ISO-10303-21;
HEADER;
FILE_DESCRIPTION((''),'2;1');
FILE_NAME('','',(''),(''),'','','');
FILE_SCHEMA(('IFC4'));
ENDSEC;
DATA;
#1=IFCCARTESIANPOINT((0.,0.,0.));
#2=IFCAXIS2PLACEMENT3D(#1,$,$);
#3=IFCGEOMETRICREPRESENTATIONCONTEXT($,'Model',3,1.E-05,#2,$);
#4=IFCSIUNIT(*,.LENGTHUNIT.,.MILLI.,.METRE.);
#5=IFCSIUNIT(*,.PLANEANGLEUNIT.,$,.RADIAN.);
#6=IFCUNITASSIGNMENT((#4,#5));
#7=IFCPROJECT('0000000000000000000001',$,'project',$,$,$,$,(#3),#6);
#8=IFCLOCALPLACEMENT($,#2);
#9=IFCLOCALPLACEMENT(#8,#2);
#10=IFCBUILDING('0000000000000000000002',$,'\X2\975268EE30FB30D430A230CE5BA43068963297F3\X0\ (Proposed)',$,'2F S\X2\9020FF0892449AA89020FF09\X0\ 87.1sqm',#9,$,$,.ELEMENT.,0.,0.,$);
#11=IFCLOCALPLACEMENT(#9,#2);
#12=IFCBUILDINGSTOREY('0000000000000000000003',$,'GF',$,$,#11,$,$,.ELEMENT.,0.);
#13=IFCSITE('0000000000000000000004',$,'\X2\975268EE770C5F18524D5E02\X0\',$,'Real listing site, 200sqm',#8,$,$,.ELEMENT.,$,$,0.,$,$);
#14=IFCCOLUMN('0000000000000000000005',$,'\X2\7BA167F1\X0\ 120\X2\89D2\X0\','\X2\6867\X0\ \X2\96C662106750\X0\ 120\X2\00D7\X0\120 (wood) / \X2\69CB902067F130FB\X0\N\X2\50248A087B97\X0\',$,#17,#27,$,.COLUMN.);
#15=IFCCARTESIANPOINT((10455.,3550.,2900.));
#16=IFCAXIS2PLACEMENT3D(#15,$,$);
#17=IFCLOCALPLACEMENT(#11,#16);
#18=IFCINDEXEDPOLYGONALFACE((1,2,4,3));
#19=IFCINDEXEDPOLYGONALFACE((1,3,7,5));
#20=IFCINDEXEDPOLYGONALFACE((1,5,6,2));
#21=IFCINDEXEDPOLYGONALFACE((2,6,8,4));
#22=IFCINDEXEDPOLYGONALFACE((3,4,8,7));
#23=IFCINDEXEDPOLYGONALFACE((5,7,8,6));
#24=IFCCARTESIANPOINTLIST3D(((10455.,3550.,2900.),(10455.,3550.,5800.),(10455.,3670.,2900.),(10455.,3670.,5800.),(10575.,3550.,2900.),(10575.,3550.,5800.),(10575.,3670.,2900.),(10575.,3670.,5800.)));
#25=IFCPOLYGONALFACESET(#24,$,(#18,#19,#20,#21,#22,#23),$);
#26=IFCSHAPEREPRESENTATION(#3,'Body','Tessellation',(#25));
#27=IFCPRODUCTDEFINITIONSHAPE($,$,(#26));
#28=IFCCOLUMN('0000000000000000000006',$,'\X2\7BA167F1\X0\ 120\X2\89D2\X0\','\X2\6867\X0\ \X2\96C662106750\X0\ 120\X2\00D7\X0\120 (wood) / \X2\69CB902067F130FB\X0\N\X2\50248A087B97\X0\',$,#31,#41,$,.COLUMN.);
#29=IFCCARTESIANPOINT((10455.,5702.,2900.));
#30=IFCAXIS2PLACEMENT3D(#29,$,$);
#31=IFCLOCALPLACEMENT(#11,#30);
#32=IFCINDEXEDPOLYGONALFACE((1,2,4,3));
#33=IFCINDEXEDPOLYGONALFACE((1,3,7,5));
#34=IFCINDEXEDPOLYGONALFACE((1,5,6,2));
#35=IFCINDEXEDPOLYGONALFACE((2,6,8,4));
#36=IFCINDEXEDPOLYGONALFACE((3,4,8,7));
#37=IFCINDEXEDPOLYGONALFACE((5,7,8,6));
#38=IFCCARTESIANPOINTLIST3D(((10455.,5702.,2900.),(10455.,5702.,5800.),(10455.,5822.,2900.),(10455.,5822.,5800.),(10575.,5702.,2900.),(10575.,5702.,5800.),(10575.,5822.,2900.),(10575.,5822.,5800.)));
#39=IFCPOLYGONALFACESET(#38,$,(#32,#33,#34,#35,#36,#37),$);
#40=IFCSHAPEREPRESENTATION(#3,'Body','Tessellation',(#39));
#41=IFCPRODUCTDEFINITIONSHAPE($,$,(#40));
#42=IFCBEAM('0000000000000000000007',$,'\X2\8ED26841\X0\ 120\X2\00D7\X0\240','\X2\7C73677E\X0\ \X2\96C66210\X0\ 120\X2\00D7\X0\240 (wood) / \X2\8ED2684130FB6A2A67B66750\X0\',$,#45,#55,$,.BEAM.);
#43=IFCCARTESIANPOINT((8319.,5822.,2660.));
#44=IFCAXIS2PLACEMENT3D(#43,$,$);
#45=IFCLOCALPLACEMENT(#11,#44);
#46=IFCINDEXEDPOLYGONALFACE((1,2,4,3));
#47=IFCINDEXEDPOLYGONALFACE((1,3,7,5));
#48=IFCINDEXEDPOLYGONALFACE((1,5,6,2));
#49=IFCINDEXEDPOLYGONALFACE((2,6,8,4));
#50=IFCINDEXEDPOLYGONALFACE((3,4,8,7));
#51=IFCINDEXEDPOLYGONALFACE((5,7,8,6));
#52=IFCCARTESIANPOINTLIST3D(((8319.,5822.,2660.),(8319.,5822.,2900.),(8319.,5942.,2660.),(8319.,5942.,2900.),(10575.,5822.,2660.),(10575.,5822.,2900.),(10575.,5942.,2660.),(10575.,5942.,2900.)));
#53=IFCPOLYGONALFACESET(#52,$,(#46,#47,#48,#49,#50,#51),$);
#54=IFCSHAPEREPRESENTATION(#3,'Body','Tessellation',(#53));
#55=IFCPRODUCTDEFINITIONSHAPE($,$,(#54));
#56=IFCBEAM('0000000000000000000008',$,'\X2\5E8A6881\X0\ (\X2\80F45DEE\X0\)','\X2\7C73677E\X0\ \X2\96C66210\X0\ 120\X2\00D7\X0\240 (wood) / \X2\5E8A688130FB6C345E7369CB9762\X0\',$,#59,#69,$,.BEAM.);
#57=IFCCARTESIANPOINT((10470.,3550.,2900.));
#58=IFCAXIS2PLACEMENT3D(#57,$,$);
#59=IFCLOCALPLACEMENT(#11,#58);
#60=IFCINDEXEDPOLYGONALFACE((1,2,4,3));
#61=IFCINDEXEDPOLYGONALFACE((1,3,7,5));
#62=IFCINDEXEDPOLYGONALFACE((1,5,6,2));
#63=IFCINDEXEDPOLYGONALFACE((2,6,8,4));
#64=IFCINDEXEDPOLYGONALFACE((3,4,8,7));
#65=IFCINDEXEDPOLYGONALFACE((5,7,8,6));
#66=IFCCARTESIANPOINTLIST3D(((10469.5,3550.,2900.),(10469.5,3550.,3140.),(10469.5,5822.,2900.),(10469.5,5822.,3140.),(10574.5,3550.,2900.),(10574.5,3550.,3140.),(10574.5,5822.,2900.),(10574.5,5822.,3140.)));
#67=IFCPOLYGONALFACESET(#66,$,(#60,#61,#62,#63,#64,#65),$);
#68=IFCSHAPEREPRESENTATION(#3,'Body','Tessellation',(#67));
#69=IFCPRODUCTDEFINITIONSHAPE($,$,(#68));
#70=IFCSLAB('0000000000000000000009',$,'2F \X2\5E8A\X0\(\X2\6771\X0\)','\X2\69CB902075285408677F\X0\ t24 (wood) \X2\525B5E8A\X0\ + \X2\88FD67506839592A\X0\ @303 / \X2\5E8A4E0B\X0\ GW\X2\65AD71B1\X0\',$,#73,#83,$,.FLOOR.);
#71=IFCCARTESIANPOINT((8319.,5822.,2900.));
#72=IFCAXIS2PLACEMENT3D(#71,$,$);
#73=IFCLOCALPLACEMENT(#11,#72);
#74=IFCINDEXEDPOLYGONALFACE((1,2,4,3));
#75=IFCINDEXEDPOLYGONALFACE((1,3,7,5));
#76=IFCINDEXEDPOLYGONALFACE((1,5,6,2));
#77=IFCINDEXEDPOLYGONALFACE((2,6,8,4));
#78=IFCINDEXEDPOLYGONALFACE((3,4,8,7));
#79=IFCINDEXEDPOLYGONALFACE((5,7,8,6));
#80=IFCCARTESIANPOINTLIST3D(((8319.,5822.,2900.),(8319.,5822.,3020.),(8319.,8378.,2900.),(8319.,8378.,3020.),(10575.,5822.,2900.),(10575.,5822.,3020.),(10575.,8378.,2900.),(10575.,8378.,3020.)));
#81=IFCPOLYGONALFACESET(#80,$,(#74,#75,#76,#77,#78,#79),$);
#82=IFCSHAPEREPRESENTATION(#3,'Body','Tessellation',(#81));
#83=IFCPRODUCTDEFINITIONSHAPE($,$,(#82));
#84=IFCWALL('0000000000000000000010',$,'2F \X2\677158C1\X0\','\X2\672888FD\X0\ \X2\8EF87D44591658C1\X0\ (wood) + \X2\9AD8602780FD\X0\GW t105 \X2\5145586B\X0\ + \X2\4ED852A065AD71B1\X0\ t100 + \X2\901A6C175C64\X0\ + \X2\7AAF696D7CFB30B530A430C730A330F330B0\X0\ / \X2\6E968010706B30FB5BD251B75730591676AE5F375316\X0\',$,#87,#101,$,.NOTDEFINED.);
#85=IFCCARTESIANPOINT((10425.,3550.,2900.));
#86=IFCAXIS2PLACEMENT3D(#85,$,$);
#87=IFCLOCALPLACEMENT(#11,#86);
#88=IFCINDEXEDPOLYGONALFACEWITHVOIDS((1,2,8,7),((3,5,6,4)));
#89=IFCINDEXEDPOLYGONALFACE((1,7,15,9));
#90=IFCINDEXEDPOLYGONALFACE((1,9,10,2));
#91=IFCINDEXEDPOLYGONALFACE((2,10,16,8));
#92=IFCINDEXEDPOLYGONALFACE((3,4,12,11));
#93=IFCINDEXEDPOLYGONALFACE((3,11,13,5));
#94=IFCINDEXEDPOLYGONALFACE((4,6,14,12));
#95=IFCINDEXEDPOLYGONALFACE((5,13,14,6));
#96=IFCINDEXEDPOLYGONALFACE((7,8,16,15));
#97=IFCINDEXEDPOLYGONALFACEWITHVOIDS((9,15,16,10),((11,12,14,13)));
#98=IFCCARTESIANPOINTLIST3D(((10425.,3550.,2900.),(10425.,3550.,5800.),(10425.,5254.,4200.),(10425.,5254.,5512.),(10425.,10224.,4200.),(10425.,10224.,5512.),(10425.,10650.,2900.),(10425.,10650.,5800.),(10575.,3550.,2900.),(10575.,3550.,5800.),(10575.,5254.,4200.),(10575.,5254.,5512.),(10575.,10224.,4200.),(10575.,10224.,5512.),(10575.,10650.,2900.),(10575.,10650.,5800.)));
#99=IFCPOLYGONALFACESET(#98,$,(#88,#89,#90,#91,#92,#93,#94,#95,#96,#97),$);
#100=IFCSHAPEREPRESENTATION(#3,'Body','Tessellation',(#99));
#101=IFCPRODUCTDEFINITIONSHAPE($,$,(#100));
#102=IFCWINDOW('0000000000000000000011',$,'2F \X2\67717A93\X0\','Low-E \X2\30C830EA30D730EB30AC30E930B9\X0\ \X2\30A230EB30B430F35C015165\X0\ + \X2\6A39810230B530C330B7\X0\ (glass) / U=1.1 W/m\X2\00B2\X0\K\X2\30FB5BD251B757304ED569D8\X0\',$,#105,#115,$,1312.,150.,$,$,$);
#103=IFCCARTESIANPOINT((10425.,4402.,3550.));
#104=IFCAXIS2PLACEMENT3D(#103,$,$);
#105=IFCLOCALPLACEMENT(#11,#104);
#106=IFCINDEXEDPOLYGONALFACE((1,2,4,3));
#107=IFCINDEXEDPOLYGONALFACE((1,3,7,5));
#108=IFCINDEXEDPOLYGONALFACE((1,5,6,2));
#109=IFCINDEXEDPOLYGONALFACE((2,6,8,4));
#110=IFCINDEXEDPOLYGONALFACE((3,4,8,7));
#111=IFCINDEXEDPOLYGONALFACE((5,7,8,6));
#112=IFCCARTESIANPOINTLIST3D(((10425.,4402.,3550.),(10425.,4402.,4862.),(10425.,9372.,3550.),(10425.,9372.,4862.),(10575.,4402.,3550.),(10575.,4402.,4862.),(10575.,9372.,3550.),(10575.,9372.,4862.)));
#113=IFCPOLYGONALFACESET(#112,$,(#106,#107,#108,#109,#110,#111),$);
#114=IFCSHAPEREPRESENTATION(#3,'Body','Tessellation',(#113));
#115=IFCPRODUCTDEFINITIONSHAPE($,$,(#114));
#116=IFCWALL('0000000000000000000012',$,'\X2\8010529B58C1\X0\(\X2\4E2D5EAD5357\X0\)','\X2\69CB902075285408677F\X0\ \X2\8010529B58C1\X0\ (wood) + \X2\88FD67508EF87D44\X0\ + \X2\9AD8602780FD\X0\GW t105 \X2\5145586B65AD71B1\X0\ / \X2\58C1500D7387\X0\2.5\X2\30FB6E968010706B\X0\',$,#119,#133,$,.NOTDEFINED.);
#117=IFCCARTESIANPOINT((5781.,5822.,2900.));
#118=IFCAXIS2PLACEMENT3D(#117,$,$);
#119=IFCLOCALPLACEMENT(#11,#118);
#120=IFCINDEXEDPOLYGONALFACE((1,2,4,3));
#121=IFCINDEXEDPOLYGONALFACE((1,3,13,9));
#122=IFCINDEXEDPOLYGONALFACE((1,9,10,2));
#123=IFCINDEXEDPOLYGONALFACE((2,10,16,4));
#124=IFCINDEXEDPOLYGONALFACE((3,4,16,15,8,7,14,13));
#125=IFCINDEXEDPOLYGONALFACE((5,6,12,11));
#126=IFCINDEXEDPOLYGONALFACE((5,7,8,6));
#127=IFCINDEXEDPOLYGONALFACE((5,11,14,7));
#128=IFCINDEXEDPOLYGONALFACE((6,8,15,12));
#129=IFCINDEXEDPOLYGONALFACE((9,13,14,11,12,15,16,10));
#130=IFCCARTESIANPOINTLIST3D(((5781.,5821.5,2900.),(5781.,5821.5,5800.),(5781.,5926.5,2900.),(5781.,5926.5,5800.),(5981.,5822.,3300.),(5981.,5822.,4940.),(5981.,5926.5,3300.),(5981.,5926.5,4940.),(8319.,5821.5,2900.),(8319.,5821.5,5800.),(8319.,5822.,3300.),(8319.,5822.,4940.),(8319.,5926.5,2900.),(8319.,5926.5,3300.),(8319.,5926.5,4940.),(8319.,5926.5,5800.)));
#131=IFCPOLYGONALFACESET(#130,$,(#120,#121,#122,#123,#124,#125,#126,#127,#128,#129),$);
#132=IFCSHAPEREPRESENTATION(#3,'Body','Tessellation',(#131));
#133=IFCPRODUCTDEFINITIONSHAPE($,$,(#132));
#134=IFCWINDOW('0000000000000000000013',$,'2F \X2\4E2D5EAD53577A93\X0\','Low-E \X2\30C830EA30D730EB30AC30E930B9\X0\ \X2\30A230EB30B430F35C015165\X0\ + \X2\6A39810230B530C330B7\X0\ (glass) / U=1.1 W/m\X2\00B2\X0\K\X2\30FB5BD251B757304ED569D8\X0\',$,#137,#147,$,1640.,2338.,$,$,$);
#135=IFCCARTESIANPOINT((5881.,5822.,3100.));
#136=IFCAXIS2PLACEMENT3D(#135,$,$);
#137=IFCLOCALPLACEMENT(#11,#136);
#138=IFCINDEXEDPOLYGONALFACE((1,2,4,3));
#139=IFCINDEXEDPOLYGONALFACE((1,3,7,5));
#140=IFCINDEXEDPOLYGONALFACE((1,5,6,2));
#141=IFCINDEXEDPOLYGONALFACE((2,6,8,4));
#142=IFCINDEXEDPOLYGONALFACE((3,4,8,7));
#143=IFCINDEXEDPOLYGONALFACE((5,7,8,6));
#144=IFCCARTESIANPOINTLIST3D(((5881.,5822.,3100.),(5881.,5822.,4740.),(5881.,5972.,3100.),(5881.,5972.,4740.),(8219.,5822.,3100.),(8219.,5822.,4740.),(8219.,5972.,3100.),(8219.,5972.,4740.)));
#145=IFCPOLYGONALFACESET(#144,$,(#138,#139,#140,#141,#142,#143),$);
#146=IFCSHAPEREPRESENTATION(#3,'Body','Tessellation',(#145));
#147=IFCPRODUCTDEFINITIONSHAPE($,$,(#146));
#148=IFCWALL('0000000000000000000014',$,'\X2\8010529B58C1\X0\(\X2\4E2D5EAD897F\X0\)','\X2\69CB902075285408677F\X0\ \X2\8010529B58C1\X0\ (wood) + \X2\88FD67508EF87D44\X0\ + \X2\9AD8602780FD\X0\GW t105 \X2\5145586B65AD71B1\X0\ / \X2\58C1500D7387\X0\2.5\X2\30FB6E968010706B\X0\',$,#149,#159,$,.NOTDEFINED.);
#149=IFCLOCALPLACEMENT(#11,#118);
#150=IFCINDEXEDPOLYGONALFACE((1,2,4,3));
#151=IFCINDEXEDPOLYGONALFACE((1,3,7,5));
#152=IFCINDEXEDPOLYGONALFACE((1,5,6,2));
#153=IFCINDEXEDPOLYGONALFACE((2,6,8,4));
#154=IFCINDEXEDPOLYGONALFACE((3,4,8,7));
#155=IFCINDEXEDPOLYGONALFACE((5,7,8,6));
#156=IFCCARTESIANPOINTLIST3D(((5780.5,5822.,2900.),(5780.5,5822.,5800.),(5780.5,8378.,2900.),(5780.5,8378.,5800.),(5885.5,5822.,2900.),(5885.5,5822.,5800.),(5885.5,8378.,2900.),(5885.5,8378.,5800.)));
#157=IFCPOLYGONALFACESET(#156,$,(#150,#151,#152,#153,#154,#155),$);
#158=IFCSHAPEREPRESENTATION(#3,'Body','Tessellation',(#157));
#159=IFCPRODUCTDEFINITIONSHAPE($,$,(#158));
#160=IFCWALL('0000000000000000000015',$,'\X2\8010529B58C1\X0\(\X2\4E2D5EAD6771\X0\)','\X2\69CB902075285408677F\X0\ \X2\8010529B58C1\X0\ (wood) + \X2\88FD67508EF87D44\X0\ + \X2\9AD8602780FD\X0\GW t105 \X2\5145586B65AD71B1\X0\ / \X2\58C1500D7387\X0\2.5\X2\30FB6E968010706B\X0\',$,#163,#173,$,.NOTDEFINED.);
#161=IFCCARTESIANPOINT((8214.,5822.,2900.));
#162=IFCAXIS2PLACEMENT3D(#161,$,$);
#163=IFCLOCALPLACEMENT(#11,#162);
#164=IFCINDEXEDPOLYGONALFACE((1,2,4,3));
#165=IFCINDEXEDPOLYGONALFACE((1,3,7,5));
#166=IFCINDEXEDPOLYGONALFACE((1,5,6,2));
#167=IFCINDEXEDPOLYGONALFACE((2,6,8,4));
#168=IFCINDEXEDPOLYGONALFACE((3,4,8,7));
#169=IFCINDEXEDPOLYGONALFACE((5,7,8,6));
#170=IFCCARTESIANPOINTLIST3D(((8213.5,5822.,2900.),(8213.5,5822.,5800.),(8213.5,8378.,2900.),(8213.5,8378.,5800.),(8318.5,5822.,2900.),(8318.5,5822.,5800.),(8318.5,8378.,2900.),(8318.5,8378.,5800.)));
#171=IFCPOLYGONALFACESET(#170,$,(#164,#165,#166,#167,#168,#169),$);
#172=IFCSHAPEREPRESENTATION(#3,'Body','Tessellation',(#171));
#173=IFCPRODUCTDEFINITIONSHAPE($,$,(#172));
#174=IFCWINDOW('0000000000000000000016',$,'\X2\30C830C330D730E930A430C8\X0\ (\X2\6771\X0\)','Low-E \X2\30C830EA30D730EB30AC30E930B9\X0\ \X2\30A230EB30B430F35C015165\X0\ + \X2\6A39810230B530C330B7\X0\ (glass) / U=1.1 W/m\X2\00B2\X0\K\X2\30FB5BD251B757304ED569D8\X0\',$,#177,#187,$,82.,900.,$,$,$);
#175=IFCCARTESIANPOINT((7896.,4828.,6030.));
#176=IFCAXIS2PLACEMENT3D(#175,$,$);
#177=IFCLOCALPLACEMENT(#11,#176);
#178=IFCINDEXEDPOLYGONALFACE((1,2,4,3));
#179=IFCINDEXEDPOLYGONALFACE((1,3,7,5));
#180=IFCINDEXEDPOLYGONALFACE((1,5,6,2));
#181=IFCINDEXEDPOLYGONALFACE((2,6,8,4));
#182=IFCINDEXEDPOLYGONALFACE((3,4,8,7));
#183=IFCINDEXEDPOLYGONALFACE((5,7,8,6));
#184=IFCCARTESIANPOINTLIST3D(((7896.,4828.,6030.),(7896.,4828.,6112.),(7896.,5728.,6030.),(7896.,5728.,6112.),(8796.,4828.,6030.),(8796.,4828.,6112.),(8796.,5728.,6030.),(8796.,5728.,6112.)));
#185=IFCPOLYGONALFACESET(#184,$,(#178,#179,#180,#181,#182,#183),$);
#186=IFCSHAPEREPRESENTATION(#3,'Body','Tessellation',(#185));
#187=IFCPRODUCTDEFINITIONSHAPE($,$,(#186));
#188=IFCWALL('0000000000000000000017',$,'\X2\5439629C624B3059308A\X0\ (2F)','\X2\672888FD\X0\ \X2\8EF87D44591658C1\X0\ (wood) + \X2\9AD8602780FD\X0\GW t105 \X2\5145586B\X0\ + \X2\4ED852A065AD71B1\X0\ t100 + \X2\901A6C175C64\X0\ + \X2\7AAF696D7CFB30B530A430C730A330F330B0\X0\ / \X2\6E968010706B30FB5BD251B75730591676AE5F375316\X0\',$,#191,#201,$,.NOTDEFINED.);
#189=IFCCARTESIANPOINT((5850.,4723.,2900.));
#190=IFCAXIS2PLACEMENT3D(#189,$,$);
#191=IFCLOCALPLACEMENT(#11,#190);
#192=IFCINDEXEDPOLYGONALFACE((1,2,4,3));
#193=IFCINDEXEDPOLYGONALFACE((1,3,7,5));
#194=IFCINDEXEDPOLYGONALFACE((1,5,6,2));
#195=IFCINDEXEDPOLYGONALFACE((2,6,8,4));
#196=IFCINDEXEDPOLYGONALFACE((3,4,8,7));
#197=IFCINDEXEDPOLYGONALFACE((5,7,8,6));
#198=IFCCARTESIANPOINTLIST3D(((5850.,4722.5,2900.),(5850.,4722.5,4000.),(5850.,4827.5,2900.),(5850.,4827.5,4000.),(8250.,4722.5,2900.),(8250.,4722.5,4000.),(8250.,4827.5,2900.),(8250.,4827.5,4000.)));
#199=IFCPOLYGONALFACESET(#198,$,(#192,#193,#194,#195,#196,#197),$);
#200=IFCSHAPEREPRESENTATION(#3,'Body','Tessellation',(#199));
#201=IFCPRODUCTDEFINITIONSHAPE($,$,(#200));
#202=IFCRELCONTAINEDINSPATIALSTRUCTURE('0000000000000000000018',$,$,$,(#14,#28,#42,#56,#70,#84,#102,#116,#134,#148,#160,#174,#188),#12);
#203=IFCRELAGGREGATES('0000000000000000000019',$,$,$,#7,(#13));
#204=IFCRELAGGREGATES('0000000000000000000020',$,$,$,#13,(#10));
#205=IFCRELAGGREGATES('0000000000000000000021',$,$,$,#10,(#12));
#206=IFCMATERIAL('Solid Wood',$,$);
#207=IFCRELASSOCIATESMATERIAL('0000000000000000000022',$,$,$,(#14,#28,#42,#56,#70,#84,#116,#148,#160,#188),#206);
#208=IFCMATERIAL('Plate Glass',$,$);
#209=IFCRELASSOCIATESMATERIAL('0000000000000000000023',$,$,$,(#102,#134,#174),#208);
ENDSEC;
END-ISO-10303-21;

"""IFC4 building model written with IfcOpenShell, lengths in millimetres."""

from ifc_helpers import new_model, si_unit, frame, frame_2d, origin, place, context, project, spatial, rectangle, extrude, material, element, fill, save


model = new_model("IFC4")

# Units and contexts
model_context = context("Model", 3, precision=1e-05, world=origin())
ifc_project = project(units=[si_unit("LENGTHUNIT", "METRE", prefix="MILLI"), si_unit("PLANEANGLEUNIT", "RADIAN")], contexts=[model_context])

# Site, building, storey
site_placement = place(None, origin())
site = spatial("IfcSite", under=ifc_project, at=site_placement, Name="青森県弘前市", ObjectType="Real listing site, 200sqm", CompositionType="ELEMENT", RefElevation=0.0)
building_placement = place(site_placement, origin())
building = spatial("IfcBuilding", under=site, at=building_placement, Name="青森・ピアノ室と防音 (Proposed)", ObjectType="2F S造（鉄骨造） 87.1sqm", CompositionType="ELEMENT", ElevationOfRefHeight=0.0, ElevationOfTerrain=0.0)
storey_placement = place(building_placement, origin())
storey = spatial("IfcBuildingStorey", under=building, at=storey_placement, Name="GF", CompositionType="ELEMENT", Elevation=0.0)

# Columns
ifc_material_1 = material(Name="Solid Wood")
column_1_placement = place(storey_placement, frame((10455.0, 3550.0, 2900.0)))
element("IfcColumn", 1, at=column_1_placement, inside=storey, material=ifc_material_1, Name="管柱 120角", Description="桧 集成材 120×120 (wood) / 構造柱・N値計算", PredefinedType="COLUMN", context=model_context, shape_type="SweptSolid", body=[
    extrude(rectangle(XDim=120.0, YDim=120.0, at=frame_2d((60.0, 60.0))), frame((10455.0, 3550.0, 2900.0)), (0.0, 0.0, 1.0), 2900.0),
])
column_2_placement = place(storey_placement, frame((10455.0, 5702.0, 2900.0)))
element("IfcColumn", 2, at=column_2_placement, inside=storey, material=ifc_material_1, Name="管柱 120角", Description="桧 集成材 120×120 (wood) / 構造柱・N値計算", PredefinedType="COLUMN", context=model_context, shape_type="SweptSolid", body=[
    extrude(rectangle(XDim=120.0, YDim=120.0, at=frame_2d((60.0, 60.0))), frame((10455.0, 5702.0, 2900.0)), (0.0, 0.0, 1.0), 2900.0),
])

# Beams
beam_1_placement = place(storey_placement, frame((8319.0, 5822.0, 2660.0)))
element("IfcBeam", 3, at=beam_1_placement, inside=storey, material=ifc_material_1, Name="軒桁 120×240", Description="米松 集成 120×240 (wood) / 軒桁・横架材", PredefinedType="BEAM", context=model_context, shape_type="SweptSolid", body=[
    extrude(rectangle(XDim=2256.0, YDim=120.0, at=frame_2d((1128.0, 60.0))), frame((8319.0, 5822.0, 2660.0)), (0.0, 0.0, 1.0), 240.0),
])
beam_2_placement = place(storey_placement, frame((10470.0, 3550.0, 2900.0)))
element("IfcBeam", 4, at=beam_2_placement, inside=storey, material=ifc_material_1, Name="床梁 (胴差)", Description="米松 集成 120×240 (wood) / 床梁・水平構面", PredefinedType="BEAM", context=model_context, shape_type="SweptSolid", body=[
    extrude(rectangle(XDim=105.0, YDim=2272.0, at=frame_2d((52.0, 1136.0))), frame((10470.0, 3550.0, 2900.0)), (0.0, 0.0, 1.0), 240.0),
])

# Slab
slab_placement = place(storey_placement, frame((8319.0, 5822.0, 2900.0)))
element("IfcSlab", 5, at=slab_placement, inside=storey, material=ifc_material_1, Name="2F 床(東)", Description="構造用合板 t24 (wood) 剛床 + 製材根太 @303 / 床下 GW断熱", PredefinedType="FLOOR", context=model_context, shape_type="SweptSolid", body=[
    extrude(rectangle(XDim=2256.0, YDim=2556.0, at=frame_2d((1128.0, 1278.0))), frame((8319.0, 5822.0, 2900.0)), (0.0, 0.0, 1.0), 120.0),
])

# Walls, openings, windows
wall_1_placement = place(storey_placement, frame((10425.0, 3550.0, 2900.0)))
wall_1 = element("IfcWall", 6, at=wall_1_placement, inside=storey, material=ifc_material_1, Name="2F 東壁", Description="木製 軸組外壁 (wood) + 高性能GW t105 充填 + 付加断熱 t100 + 通気層 + 窯業系サイディング / 準耐火・寒冷地外皮強化", PredefinedType="NOTDEFINED", context=model_context, shape_type="SweptSolid", body=[
    extrude(rectangle(XDim=150.0, YDim=7100.0, at=frame_2d((75.0, 3550.0))), frame((10425.0, 3550.0, 2900.0)), (0.0, 0.0, 1.0), 2900.0),
])
opening_1_placement = place(storey_placement, frame((10425.0, 4402.0, 3550.0)))
opening_1 = element("IfcOpeningElement", 7, at=opening_1_placement, cuts=wall_1, PredefinedType="NOTDEFINED", context=model_context, shape_type="SweptSolid", body=[
    extrude(rectangle(XDim=150.0, YDim=4970.0, at=frame_2d((75.0, 2485.0))), frame((10425.0, 4402.0, 3550.0)), (0.0, 0.0, 1.0), 1312.0),
])
ifc_material_2 = material(Name="Plate Glass")
window_1_placement = place(storey_placement, frame((10425.0, 4402.0, 3550.0)))
window_1 = element("IfcWindow", 8, at=window_1_placement, inside=storey, material=ifc_material_2, Name="2F 東窓", Description="Low-E トリプルガラス アルゴン封入 + 樹脂サッシ (glass) / U=1.1 W/m²K・寒冷地仕様", OverallHeight=1312.0, OverallWidth=150.0, context=model_context, shape_type="SweptSolid", body=[
    extrude(rectangle(XDim=150.0, YDim=4970.0, at=frame_2d((75.0, 2485.0))), frame((10425.0, 4402.0, 3550.0)), (0.0, 0.0, 1.0), 1312.0),
])
fill(opening_1, window_1)
wall_2_placement = place(storey_placement, frame((5781.0, 5822.0, 2900.0)))
wall_2 = element("IfcWall", 9, at=wall_2_placement, inside=storey, material=ifc_material_1, Name="耐力壁(中庭南)", Description="構造用合板 耐力壁 (wood) + 製材軸組 + 高性能GW t105 充填断熱 / 壁倍率2.5・準耐火", PredefinedType="NOTDEFINED", context=model_context, shape_type="SweptSolid", body=[
    extrude(rectangle(XDim=2538.0, YDim=105.0, at=frame_2d((1269.0, 52.0))), frame((5781.0, 5822.0, 2900.0)), (0.0, 0.0, 1.0), 2900.0),
])
opening_2_placement = place(storey_placement, frame((5881.0, 5822.0, 3100.0)))
opening_2 = element("IfcOpeningElement", 10, at=opening_2_placement, cuts=wall_2, PredefinedType="NOTDEFINED", context=model_context, shape_type="SweptSolid", body=[
    extrude(rectangle(XDim=2338.0, YDim=150.0, at=frame_2d((1169.0, 75.0))), frame((5881.0, 5822.0, 3100.0)), (0.0, 0.0, 1.0), 1640.0),
])
window_2_placement = place(storey_placement, frame((5881.0, 5822.0, 3100.0)))
window_2 = element("IfcWindow", 11, at=window_2_placement, inside=storey, material=ifc_material_2, Name="2F 中庭南窓", Description="Low-E トリプルガラス アルゴン封入 + 樹脂サッシ (glass) / U=1.1 W/m²K・寒冷地仕様", OverallHeight=1640.0, OverallWidth=2338.0, context=model_context, shape_type="SweptSolid", body=[
    extrude(rectangle(XDim=2338.0, YDim=150.0, at=frame_2d((1169.0, 75.0))), frame((5881.0, 5822.0, 3100.0)), (0.0, 0.0, 1.0), 1640.0),
])
fill(opening_2, window_2)

# Walls
wall_3_placement = place(storey_placement, frame((5781.0, 5822.0, 2900.0)))
element("IfcWall", 12, at=wall_3_placement, inside=storey, material=ifc_material_1, Name="耐力壁(中庭西)", Description="構造用合板 耐力壁 (wood) + 製材軸組 + 高性能GW t105 充填断熱 / 壁倍率2.5・準耐火", PredefinedType="NOTDEFINED", context=model_context, shape_type="SweptSolid", body=[
    extrude(rectangle(XDim=105.0, YDim=2556.0, at=frame_2d((52.0, 1278.0))), frame((5781.0, 5822.0, 2900.0)), (0.0, 0.0, 1.0), 2900.0),
])
wall_4_placement = place(storey_placement, frame((8214.0, 5822.0, 2900.0)))
element("IfcWall", 13, at=wall_4_placement, inside=storey, material=ifc_material_1, Name="耐力壁(中庭東)", Description="構造用合板 耐力壁 (wood) + 製材軸組 + 高性能GW t105 充填断熱 / 壁倍率2.5・準耐火", PredefinedType="NOTDEFINED", context=model_context, shape_type="SweptSolid", body=[
    extrude(rectangle(XDim=105.0, YDim=2556.0, at=frame_2d((52.0, 1278.0))), frame((8214.0, 5822.0, 2900.0)), (0.0, 0.0, 1.0), 2900.0),
])

# Window
window_3_placement = place(storey_placement, frame((7896.0, 4828.0, 6030.0)))
element("IfcWindow", 14, at=window_3_placement, inside=storey, material=ifc_material_2, Name="トップライト (東)", Description="Low-E トリプルガラス アルゴン封入 + 樹脂サッシ (glass) / U=1.1 W/m²K・寒冷地仕様", OverallHeight=82.0, OverallWidth=900.0, context=model_context, shape_type="SweptSolid", body=[
    extrude(rectangle(XDim=900.0, YDim=900.0, at=frame_2d((450.0, 450.0))), frame((7896.0, 4828.0, 6030.0)), (0.0, 0.0, 1.0), 82.0),
])

# Wall
wall_5_placement = place(storey_placement, frame((5850.0, 4723.0, 2900.0)))
element("IfcWall", 15, at=wall_5_placement, inside=storey, material=ifc_material_1, Name="吹抜手すり (2F)", Description="木製 軸組外壁 (wood) + 高性能GW t105 充填 + 付加断熱 t100 + 通気層 + 窯業系サイディング / 準耐火・寒冷地外皮強化", PredefinedType="NOTDEFINED", context=model_context, shape_type="SweptSolid", body=[
    extrude(rectangle(XDim=2400.0, YDim=105.0, at=frame_2d((1200.0, 52.0))), frame((5850.0, 4723.0, 2900.0)), (0.0, 0.0, 1.0), 1100.0),
])

save(model, "model.ifc")
